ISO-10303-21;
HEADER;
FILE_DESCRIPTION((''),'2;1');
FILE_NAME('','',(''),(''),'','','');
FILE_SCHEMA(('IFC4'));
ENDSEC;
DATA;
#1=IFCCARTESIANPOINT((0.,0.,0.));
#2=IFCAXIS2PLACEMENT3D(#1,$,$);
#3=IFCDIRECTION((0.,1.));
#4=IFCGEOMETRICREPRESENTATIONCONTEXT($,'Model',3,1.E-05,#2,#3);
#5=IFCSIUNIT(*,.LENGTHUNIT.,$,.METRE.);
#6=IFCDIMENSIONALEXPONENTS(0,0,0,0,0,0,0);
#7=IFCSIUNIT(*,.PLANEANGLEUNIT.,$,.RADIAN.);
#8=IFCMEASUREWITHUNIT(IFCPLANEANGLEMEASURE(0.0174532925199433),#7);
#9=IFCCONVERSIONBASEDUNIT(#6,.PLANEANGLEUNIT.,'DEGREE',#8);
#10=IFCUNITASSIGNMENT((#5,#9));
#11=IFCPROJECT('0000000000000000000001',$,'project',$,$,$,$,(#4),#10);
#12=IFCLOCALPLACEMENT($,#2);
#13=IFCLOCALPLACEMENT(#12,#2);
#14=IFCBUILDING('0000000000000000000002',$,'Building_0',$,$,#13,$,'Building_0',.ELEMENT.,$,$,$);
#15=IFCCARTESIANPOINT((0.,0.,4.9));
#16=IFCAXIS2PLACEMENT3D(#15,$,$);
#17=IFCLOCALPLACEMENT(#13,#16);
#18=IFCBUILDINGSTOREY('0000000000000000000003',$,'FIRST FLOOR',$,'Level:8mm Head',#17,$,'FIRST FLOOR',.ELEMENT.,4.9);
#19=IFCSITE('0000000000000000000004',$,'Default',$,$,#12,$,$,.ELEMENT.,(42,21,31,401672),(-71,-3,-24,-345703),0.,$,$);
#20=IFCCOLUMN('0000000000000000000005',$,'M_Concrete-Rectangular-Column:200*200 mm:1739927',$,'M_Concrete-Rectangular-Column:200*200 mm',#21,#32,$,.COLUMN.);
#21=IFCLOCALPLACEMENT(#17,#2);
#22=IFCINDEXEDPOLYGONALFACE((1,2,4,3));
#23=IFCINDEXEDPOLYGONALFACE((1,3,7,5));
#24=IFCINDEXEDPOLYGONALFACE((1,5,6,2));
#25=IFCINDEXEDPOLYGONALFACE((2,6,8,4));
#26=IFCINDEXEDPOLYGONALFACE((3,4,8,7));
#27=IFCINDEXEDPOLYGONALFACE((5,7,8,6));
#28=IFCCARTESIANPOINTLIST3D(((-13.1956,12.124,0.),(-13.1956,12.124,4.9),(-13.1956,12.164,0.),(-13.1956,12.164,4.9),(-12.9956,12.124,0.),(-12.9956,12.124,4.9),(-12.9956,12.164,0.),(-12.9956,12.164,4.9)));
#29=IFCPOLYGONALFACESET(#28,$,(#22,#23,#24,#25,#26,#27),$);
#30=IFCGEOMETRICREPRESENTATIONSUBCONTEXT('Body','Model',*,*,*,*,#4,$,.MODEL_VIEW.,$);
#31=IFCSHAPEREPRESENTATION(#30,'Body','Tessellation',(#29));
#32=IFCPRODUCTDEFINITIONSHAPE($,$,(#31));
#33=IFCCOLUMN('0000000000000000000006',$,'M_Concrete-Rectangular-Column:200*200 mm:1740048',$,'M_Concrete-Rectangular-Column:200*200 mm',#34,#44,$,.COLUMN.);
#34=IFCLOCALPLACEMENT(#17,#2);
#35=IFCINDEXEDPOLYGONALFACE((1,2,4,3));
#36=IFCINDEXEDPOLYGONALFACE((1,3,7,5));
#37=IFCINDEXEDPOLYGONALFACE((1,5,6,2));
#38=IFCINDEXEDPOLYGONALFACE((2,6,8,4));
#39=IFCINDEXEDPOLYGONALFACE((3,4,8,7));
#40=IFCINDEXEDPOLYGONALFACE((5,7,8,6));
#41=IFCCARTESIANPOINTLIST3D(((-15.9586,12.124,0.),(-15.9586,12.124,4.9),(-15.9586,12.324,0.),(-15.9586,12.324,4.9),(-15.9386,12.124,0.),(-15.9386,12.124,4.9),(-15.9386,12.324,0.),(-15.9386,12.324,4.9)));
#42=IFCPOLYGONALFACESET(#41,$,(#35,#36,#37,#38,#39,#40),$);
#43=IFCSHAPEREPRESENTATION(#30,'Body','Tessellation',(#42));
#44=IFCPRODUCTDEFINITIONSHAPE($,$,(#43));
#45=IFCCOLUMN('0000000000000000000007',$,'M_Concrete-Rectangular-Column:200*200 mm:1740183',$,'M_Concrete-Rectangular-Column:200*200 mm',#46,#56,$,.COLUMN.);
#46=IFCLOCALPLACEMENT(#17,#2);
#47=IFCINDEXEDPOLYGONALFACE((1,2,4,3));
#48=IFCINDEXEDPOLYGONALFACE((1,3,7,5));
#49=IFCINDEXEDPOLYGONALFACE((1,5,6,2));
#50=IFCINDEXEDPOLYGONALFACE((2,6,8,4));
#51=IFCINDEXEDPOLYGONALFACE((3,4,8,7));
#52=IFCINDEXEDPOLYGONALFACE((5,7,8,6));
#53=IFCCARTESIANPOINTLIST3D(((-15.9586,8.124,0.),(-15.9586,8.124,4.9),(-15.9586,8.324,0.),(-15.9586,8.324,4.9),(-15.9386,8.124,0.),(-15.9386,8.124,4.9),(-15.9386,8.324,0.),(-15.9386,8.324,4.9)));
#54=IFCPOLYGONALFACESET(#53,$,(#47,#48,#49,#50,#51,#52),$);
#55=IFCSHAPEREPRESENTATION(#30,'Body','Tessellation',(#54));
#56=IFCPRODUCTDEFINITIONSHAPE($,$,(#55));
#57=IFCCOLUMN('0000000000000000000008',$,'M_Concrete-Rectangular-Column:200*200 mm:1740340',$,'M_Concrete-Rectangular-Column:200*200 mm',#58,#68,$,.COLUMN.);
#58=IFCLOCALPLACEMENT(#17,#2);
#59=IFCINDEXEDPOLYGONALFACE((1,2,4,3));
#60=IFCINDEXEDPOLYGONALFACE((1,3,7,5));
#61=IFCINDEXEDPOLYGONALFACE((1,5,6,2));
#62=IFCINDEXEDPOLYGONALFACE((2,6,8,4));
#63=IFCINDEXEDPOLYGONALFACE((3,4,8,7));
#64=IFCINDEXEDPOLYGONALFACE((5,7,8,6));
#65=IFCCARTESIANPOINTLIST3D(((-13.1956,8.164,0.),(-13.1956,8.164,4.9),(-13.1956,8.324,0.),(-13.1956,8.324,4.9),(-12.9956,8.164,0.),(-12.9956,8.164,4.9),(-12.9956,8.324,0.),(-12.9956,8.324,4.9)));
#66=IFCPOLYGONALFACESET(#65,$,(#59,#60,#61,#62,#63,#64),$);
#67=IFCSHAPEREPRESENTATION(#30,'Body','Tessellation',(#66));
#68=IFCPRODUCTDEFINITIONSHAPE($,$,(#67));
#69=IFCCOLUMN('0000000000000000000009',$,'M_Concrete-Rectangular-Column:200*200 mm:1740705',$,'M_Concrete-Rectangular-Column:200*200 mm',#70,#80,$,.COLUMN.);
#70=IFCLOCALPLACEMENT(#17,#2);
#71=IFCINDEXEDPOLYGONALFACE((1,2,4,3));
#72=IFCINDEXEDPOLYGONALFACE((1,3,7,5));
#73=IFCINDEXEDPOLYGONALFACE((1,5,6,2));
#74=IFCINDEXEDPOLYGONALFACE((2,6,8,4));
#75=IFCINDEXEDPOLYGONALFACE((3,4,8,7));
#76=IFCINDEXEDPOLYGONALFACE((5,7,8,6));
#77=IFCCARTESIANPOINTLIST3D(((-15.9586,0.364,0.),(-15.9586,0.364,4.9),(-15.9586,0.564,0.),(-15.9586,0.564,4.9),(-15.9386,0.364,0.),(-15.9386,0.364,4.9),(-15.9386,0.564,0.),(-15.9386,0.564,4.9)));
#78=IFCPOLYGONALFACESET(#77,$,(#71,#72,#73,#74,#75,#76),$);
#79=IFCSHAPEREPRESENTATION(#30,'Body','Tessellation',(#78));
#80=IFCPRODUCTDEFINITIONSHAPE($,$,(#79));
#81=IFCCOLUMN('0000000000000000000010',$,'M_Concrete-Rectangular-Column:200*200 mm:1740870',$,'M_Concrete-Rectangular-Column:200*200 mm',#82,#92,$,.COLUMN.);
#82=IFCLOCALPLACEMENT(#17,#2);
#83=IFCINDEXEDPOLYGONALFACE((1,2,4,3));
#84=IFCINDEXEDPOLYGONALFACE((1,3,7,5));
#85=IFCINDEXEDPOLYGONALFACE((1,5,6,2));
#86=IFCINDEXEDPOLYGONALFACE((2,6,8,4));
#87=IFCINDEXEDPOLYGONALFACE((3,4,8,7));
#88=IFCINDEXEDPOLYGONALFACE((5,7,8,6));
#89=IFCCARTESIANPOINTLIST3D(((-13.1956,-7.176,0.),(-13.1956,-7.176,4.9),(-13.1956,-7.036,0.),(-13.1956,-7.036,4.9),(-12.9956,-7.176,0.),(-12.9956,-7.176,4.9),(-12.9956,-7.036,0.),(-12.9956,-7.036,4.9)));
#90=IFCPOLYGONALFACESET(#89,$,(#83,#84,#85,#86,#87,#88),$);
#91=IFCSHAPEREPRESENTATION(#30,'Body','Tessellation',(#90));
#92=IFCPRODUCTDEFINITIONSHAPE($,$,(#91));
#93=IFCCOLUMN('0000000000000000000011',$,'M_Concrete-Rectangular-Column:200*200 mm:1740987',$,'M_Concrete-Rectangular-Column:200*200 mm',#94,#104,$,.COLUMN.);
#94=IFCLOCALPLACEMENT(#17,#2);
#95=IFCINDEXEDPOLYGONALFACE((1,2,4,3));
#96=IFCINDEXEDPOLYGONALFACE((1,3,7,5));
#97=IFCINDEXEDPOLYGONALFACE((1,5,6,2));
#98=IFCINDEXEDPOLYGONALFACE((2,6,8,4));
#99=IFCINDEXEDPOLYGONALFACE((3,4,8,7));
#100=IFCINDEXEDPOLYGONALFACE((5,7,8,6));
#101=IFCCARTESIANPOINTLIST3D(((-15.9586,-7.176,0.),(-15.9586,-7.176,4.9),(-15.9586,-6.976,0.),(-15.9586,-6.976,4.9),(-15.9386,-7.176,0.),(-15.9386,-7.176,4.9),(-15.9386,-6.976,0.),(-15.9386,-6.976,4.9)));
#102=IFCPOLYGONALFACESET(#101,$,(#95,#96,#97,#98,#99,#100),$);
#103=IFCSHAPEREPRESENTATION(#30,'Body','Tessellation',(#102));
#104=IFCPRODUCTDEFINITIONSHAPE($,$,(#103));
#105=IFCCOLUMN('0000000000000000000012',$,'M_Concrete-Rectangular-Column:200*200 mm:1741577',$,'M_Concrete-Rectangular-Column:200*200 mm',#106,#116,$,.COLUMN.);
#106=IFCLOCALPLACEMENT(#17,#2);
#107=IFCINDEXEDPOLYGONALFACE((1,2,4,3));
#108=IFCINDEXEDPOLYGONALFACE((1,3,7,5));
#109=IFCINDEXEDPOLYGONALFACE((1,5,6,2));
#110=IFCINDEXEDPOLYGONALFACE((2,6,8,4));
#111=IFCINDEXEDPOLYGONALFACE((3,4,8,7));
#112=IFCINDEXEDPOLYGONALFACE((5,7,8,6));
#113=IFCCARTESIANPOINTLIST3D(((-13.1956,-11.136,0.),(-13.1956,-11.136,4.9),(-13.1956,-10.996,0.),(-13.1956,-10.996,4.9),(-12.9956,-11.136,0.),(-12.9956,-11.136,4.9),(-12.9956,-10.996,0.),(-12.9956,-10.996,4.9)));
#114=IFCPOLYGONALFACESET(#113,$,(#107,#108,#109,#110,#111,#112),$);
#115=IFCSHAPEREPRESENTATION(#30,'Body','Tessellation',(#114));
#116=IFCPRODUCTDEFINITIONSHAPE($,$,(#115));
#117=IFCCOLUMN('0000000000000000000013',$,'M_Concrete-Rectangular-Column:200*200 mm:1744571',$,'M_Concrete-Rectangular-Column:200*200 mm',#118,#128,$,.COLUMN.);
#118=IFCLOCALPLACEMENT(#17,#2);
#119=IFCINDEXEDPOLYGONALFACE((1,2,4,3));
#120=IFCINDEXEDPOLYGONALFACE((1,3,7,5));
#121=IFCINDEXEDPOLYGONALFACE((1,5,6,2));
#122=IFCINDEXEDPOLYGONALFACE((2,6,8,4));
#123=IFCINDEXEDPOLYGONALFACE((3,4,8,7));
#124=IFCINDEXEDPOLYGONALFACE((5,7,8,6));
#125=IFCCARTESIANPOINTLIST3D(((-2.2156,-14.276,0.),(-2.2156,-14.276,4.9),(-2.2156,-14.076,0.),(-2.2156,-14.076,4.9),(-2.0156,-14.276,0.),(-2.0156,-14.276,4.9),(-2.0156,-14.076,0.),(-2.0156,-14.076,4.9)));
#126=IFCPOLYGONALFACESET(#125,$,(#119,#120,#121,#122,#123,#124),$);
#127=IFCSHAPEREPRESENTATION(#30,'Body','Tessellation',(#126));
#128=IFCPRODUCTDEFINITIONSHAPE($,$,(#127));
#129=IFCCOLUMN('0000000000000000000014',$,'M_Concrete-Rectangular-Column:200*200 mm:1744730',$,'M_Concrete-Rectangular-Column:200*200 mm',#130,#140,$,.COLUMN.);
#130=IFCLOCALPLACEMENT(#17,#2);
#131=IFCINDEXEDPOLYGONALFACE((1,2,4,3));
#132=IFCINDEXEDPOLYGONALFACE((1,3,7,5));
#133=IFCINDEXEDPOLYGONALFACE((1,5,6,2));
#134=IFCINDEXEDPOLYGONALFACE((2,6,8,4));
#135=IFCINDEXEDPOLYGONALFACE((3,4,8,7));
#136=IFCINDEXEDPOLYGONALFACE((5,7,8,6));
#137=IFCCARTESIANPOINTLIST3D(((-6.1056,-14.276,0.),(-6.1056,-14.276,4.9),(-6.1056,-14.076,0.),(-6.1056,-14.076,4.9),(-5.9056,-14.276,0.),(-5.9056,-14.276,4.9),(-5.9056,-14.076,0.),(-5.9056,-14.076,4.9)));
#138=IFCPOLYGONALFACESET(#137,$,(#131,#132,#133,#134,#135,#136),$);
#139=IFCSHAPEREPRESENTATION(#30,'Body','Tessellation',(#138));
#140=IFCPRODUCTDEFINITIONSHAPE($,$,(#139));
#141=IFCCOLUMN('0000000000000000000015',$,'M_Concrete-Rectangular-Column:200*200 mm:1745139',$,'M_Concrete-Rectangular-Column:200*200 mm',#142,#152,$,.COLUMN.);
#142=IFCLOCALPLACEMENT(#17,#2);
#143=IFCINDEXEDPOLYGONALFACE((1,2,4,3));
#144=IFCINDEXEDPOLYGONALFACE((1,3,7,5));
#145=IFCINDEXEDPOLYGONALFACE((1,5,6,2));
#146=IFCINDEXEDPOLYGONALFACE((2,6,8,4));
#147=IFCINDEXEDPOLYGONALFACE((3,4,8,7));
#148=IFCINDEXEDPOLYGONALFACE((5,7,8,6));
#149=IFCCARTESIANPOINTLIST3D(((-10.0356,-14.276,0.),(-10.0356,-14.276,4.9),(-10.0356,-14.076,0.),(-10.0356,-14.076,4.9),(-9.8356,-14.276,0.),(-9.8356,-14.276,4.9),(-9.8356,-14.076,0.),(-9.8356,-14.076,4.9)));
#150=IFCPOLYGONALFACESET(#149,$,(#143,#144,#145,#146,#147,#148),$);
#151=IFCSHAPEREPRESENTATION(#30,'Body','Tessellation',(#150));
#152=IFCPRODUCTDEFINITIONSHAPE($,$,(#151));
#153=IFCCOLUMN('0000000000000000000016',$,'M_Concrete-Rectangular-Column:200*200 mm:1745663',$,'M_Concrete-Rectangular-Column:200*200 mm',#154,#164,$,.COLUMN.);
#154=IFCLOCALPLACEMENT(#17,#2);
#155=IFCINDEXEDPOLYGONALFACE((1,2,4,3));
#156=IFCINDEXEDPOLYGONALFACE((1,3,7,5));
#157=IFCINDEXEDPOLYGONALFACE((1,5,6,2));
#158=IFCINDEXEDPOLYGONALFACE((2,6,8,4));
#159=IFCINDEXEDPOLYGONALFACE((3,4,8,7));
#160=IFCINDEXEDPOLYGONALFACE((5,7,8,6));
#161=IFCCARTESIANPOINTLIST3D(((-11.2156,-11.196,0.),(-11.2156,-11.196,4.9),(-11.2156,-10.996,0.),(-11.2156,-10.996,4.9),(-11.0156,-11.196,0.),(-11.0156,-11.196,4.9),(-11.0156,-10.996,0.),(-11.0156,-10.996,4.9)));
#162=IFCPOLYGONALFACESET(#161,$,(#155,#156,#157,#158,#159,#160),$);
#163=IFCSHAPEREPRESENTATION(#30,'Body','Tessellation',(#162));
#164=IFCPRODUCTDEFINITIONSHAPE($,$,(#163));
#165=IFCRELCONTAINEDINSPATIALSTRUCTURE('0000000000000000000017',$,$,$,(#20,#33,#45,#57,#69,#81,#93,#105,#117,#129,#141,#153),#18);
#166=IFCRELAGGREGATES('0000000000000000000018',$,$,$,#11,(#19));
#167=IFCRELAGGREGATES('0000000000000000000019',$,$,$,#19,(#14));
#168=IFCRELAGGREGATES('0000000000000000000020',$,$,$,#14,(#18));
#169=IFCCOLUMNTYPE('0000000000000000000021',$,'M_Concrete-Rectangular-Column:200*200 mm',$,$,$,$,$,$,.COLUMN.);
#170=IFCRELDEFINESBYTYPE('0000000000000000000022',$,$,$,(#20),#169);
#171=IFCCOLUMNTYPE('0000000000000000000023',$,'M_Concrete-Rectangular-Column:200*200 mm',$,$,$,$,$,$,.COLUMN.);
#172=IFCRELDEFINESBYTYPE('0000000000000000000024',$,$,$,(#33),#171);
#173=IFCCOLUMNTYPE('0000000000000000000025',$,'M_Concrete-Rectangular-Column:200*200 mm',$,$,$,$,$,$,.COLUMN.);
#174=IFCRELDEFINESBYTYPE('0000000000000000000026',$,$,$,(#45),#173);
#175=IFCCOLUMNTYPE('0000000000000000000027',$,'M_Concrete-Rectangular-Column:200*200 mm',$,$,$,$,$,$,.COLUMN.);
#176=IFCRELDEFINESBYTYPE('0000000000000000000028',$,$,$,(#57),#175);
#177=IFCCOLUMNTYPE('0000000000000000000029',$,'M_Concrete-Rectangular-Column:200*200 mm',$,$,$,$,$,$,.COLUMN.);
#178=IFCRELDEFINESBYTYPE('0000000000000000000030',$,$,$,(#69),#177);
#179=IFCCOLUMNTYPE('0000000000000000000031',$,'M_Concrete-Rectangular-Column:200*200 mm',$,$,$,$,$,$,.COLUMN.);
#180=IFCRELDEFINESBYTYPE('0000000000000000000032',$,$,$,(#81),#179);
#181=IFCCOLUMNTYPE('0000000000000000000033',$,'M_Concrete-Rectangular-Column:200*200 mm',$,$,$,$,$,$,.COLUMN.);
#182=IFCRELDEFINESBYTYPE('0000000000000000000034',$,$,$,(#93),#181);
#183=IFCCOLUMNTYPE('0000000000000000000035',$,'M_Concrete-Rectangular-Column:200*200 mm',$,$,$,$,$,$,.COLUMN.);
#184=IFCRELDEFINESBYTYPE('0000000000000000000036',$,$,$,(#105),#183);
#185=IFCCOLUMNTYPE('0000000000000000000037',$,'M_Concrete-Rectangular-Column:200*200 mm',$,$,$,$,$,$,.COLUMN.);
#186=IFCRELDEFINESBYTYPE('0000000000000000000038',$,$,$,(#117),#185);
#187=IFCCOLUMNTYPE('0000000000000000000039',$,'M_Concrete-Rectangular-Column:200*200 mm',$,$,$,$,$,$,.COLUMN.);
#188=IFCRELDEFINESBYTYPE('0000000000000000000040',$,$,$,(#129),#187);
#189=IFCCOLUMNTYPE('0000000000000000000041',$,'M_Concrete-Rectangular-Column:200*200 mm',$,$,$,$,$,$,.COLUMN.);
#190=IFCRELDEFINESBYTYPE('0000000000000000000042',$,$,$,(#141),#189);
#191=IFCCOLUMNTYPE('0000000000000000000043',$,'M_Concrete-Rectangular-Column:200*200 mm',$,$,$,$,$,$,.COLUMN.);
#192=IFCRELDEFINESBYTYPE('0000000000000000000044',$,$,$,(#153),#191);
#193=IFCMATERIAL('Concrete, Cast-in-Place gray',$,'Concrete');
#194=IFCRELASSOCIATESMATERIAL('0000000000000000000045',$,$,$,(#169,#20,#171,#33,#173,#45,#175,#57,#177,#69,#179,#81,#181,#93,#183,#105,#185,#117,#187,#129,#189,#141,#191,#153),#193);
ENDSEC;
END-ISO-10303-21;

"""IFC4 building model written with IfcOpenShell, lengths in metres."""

from ifc_helpers import new_model, entity, si_unit, converted_unit, direction, frame, origin, place, context, subcontext, project, spatial, indexed_curve, outline, extrude, source, transform, mapped, material, type_object, type_shapes, element, save


model = new_model("IFC4")

# Units and contexts
model_context = context("Model", 3, precision=1e-05, world=origin(), true_north=direction((0.0, 1.0)))
body_context = subcontext(model_context, "Body", "Model", "MODEL_VIEW")
ifc_project = project(units=[si_unit("LENGTHUNIT", "METRE"), converted_unit("PLANEANGLEUNIT", "DEGREE", entity("IfcPlaneAngleMeasure", 0.0174532925199433), si_unit("PLANEANGLEUNIT", "RADIAN"), dimensions=[0, 0, 0, 0, 0, 0, 0])], contexts=[model_context])

# Site, building, storey
site_placement = place(None, origin())
site = spatial("IfcSite", under=ifc_project, at=site_placement, Name="Default", CompositionType="ELEMENT", RefLatitude=(42, 21, 31, 401672), RefLongitude=(-71, -3, -24, -345703), RefElevation=0.0)
building_placement = place(site_placement, origin())
building = spatial("IfcBuilding", under=site, at=building_placement, Name="Building_0", LongName="Building_0", CompositionType="ELEMENT")
storey_placement = place(building_placement, frame((0.0, 0.0, 4.9)))
storey = spatial("IfcBuildingStorey", under=building, at=storey_placement, Name="FIRST FLOOR", ObjectType="Level:8mm Head", LongName="FIRST FLOOR", CompositionType="ELEMENT", Elevation=4.9)

# Columns
ifc_material_1 = material(Name="Concrete, Cast-in-Place gray", Category="Concrete")
column_type_1 = type_object("IfcColumnType", Name="M_Concrete-Rectangular-Column:200*200 mm", PredefinedType="COLUMN", material=ifc_material_1)
shared_shape_1 = source(origin(), body_context, "Body", "SweptSolid", [
    extrude(outline(indexed_curve([(-0.02, -0.1), (0.02, -0.1), (0.02, 0.1), (-0.02, 0.1), (-0.02, -0.1)], self_intersect=False)), frame((-13.0956, 12.144, 4.9), z_axis=(0.0, 0.0, 1.0), x_axis=(0.0, 1.0, 0.0)), (0.0, 0.0, 1.0), 4.9),
])
type_shapes(column_type_1, [shared_shape_1])
column_1_placement = place(storey_placement, frame((0.0, 0.0, -4.9)))
element("IfcColumn", 1, at=column_1_placement, inside=storey, type_object=column_type_1, material=ifc_material_1, Name="M_Concrete-Rectangular-Column:200*200 mm:1739927", ObjectType="M_Concrete-Rectangular-Column:200*200 mm", PredefinedType="COLUMN", context=body_context, shape_type="MappedRepresentation", body=[
    mapped(shared_shape_1, transform((0.0, 0.0, 0.0), scale=1.0)),
])
column_type_2 = type_object("IfcColumnType", Name="M_Concrete-Rectangular-Column:200*200 mm", PredefinedType="COLUMN", material=ifc_material_1)
shared_shape_2 = source(origin(), body_context, "Body", "SweptSolid", [
    extrude(outline(indexed_curve([(-0.01, -0.1), (0.01, -0.1), (0.01, 0.1), (-0.01, 0.1), (-0.01, -0.1)], self_intersect=False)), frame((-15.9486, 12.224, 4.9), z_axis=(0.0, 0.0, 1.0), x_axis=(-1.0, 0.0, 0.0)), (0.0, 0.0, 1.0), 4.9),
])
type_shapes(column_type_2, [shared_shape_2])
column_2_placement = place(storey_placement, frame((0.0, 0.0, -4.9)))
element("IfcColumn", 2, at=column_2_placement, inside=storey, type_object=column_type_2, material=ifc_material_1, Name="M_Concrete-Rectangular-Column:200*200 mm:1740048", ObjectType="M_Concrete-Rectangular-Column:200*200 mm", PredefinedType="COLUMN", context=body_context, shape_type="MappedRepresentation", body=[
    mapped(shared_shape_2, transform((0.0, 0.0, 0.0), scale=1.0)),
])
column_type_3 = type_object("IfcColumnType", Name="M_Concrete-Rectangular-Column:200*200 mm", PredefinedType="COLUMN", material=ifc_material_1)
shared_shape_3 = source(origin(), body_context, "Body", "SweptSolid", [
    extrude(outline(indexed_curve([(-0.01, -0.1), (0.01, -0.1), (0.01, 0.1), (-0.01, 0.1), (-0.01, -0.1)], self_intersect=False)), frame((-15.9486, 8.224, 4.9), z_axis=(0.0, 0.0, 1.0), x_axis=(-1.0, 0.0, 0.0)), (0.0, 0.0, 1.0), 4.9),
])
type_shapes(column_type_3, [shared_shape_3])
column_3_placement = place(storey_placement, frame((0.0, 0.0, -4.9)))
element("IfcColumn", 3, at=column_3_placement, inside=storey, type_object=column_type_3, material=ifc_material_1, Name="M_Concrete-Rectangular-Column:200*200 mm:1740183", ObjectType="M_Concrete-Rectangular-Column:200*200 mm", PredefinedType="COLUMN", context=body_context, shape_type="MappedRepresentation", body=[
    mapped(shared_shape_3, transform((0.0, 0.0, 0.0), scale=1.0)),
])
column_type_4 = type_object("IfcColumnType", Name="M_Concrete-Rectangular-Column:200*200 mm", PredefinedType="COLUMN", material=ifc_material_1)
shared_shape_4 = source(origin(), body_context, "Body", "SweptSolid", [
    extrude(outline(indexed_curve([(-0.08, -0.1), (0.08, -0.1), (0.08, 0.1), (-0.08, 0.1), (-0.08, -0.1)], self_intersect=False)), frame((-13.0956, 8.244, 4.9), z_axis=(0.0, 0.0, 1.0), x_axis=(0.0, -1.0, 0.0)), (0.0, 0.0, 1.0), 4.9),
])
type_shapes(column_type_4, [shared_shape_4])
column_4_placement = place(storey_placement, frame((0.0, 0.0, -4.9)))
element("IfcColumn", 4, at=column_4_placement, inside=storey, type_object=column_type_4, material=ifc_material_1, Name="M_Concrete-Rectangular-Column:200*200 mm:1740340", ObjectType="M_Concrete-Rectangular-Column:200*200 mm", PredefinedType="COLUMN", context=body_context, shape_type="MappedRepresentation", body=[
    mapped(shared_shape_4, transform((0.0, 0.0, 0.0), scale=1.0)),
])
column_type_5 = type_object("IfcColumnType", Name="M_Concrete-Rectangular-Column:200*200 mm", PredefinedType="COLUMN", material=ifc_material_1)
shared_shape_5 = source(origin(), body_context, "Body", "SweptSolid", [
    extrude(outline(indexed_curve([(-0.01, -0.1), (0.01, -0.1), (0.01, 0.1), (-0.01, 0.1), (-0.01, -0.1)], self_intersect=False)), frame((-15.9486, 0.464, 4.9), z_axis=(0.0, 0.0, 1.0), x_axis=(-1.0, 0.0, 0.0)), (0.0, 0.0, 1.0), 4.9),
])
type_shapes(column_type_5, [shared_shape_5])
column_5_placement = place(storey_placement, frame((0.0, 0.0, -4.9)))
element("IfcColumn", 5, at=column_5_placement, inside=storey, type_object=column_type_5, material=ifc_material_1, Name="M_Concrete-Rectangular-Column:200*200 mm:1740705", ObjectType="M_Concrete-Rectangular-Column:200*200 mm", PredefinedType="COLUMN", context=body_context, shape_type="MappedRepresentation", body=[
    mapped(shared_shape_5, transform((0.0, 0.0, 0.0), scale=1.0)),
])
column_type_6 = type_object("IfcColumnType", Name="M_Concrete-Rectangular-Column:200*200 mm", PredefinedType="COLUMN", material=ifc_material_1)
shared_shape_6 = source(origin(), body_context, "Body", "SweptSolid", [
    extrude(outline(indexed_curve([(-0.07, -0.1), (0.07, -0.1), (0.07, 0.1), (-0.07, 0.1), (-0.07, -0.1)], self_intersect=False)), frame((-13.0956, -7.106, 4.9), z_axis=(0.0, 0.0, 1.0), x_axis=(0.0, 1.0, 0.0)), (0.0, 0.0, 1.0), 4.9),
])
type_shapes(column_type_6, [shared_shape_6])
column_6_placement = place(storey_placement, frame((0.0, 0.0, -4.9)))
element("IfcColumn", 6, at=column_6_placement, inside=storey, type_object=column_type_6, material=ifc_material_1, Name="M_Concrete-Rectangular-Column:200*200 mm:1740870", ObjectType="M_Concrete-Rectangular-Column:200*200 mm", PredefinedType="COLUMN", context=body_context, shape_type="MappedRepresentation", body=[
    mapped(shared_shape_6, transform((0.0, 0.0, 0.0), scale=1.0)),
])
column_type_7 = type_object("IfcColumnType", Name="M_Concrete-Rectangular-Column:200*200 mm", PredefinedType="COLUMN", material=ifc_material_1)
shared_shape_7 = source(origin(), body_context, "Body", "SweptSolid", [
    extrude(outline(indexed_curve([(-0.01, -0.1), (0.01, -0.1), (0.01, 0.1), (-0.01, 0.1), (-0.01, -0.1)], self_intersect=False)), frame((-15.9486, -7.076, 4.9), z_axis=(0.0, 0.0, 1.0), x_axis=(-1.0, 0.0, 0.0)), (0.0, 0.0, 1.0), 4.9),
])
type_shapes(column_type_7, [shared_shape_7])
column_7_placement = place(storey_placement, frame((0.0, 0.0, -4.9)))
element("IfcColumn", 7, at=column_7_placement, inside=storey, type_object=column_type_7, material=ifc_material_1, Name="M_Concrete-Rectangular-Column:200*200 mm:1740987", ObjectType="M_Concrete-Rectangular-Column:200*200 mm", PredefinedType="COLUMN", context=body_context, shape_type="MappedRepresentation", body=[
    mapped(shared_shape_7, transform((0.0, 0.0, 0.0), scale=1.0)),
])
column_type_8 = type_object("IfcColumnType", Name="M_Concrete-Rectangular-Column:200*200 mm", PredefinedType="COLUMN", material=ifc_material_1)
shared_shape_8 = source(origin(), body_context, "Body", "SweptSolid", [
    extrude(outline(indexed_curve([(-0.07, -0.1), (0.07, -0.1), (0.07, 0.1), (-0.07, 0.1), (-0.07, -0.1)], self_intersect=False)), frame((-13.0956, -11.066, 4.9), z_axis=(0.0, 0.0, 1.0), x_axis=(0.0, -1.0, 0.0)), (0.0, 0.0, 1.0), 4.9),
])
type_shapes(column_type_8, [shared_shape_8])
column_8_placement = place(storey_placement, frame((0.0, 0.0, -4.9)))
element("IfcColumn", 8, at=column_8_placement, inside=storey, type_object=column_type_8, material=ifc_material_1, Name="M_Concrete-Rectangular-Column:200*200 mm:1741577", ObjectType="M_Concrete-Rectangular-Column:200*200 mm", PredefinedType="COLUMN", context=body_context, shape_type="MappedRepresentation", body=[
    mapped(shared_shape_8, transform((0.0, 0.0, 0.0), scale=1.0)),
])
column_type_9 = type_object("IfcColumnType", Name="M_Concrete-Rectangular-Column:200*200 mm", PredefinedType="COLUMN", material=ifc_material_1)
shared_shape_9 = source(origin(), body_context, "Body", "SweptSolid", [
    extrude(outline(indexed_curve([(-0.1, -0.1), (0.1, -0.1), (0.1, 0.1), (-0.1, 0.1), (-0.1, -0.1)], self_intersect=False)), frame((-2.1156, -14.176, 4.9), z_axis=(0.0, 0.0, 1.0), x_axis=(-1.0, 0.0, 0.0)), (0.0, 0.0, 1.0), 4.9),
])
type_shapes(column_type_9, [shared_shape_9])
column_9_placement = place(storey_placement, frame((0.0, 0.0, -4.9)))
element("IfcColumn", 9, at=column_9_placement, inside=storey, type_object=column_type_9, material=ifc_material_1, Name="M_Concrete-Rectangular-Column:200*200 mm:1744571", ObjectType="M_Concrete-Rectangular-Column:200*200 mm", PredefinedType="COLUMN", context=body_context, shape_type="MappedRepresentation", body=[
    mapped(shared_shape_9, transform((0.0, 0.0, 0.0), scale=1.0)),
])
column_type_10 = type_object("IfcColumnType", Name="M_Concrete-Rectangular-Column:200*200 mm", PredefinedType="COLUMN", material=ifc_material_1)
shared_shape_10 = source(origin(), body_context, "Body", "SweptSolid", [
    extrude(outline(indexed_curve([(-0.1, -0.1), (0.1, -0.1), (0.1, 0.1), (-0.1, 0.1), (-0.1, -0.1)], self_intersect=False)), frame((-6.0056, -14.176, 4.9), z_axis=(0.0, 0.0, 1.0), x_axis=(-1.0, 0.0, 0.0)), (0.0, 0.0, 1.0), 4.9),
])
type_shapes(column_type_10, [shared_shape_10])
column_10_placement = place(storey_placement, frame((0.0, 0.0, -4.9)))
element("IfcColumn", 10, at=column_10_placement, inside=storey, type_object=column_type_10, material=ifc_material_1, Name="M_Concrete-Rectangular-Column:200*200 mm:1744730", ObjectType="M_Concrete-Rectangular-Column:200*200 mm", PredefinedType="COLUMN", context=body_context, shape_type="MappedRepresentation", body=[
    mapped(shared_shape_10, transform((0.0, 0.0, 0.0), scale=1.0)),
])
column_type_11 = type_object("IfcColumnType", Name="M_Concrete-Rectangular-Column:200*200 mm", PredefinedType="COLUMN", material=ifc_material_1)
shared_shape_11 = source(origin(), body_context, "Body", "SweptSolid", [
    extrude(outline(indexed_curve([(-0.1, -0.1), (0.1, -0.1), (0.1, 0.1), (-0.1, 0.1), (-0.1, -0.1)], self_intersect=False)), frame((-9.9356, -14.176, 4.9), z_axis=(0.0, 0.0, 1.0), x_axis=(-1.0, 0.0, 0.0)), (0.0, 0.0, 1.0), 4.9),
])
type_shapes(column_type_11, [shared_shape_11])
column_11_placement = place(storey_placement, frame((0.0, 0.0, -4.9)))
element("IfcColumn", 11, at=column_11_placement, inside=storey, type_object=column_type_11, material=ifc_material_1, Name="M_Concrete-Rectangular-Column:200*200 mm:1745139", ObjectType="M_Concrete-Rectangular-Column:200*200 mm", PredefinedType="COLUMN", context=body_context, shape_type="MappedRepresentation", body=[
    mapped(shared_shape_11, transform((0.0, 0.0, 0.0), scale=1.0)),
])
column_type_12 = type_object("IfcColumnType", Name="M_Concrete-Rectangular-Column:200*200 mm", PredefinedType="COLUMN", material=ifc_material_1)
shared_shape_12 = source(origin(), body_context, "Body", "SweptSolid", [
    extrude(outline(indexed_curve([(-0.1, -0.1), (0.1, -0.1), (0.1, 0.1), (-0.1, 0.1), (-0.1, -0.1)], self_intersect=False)), frame((-11.1156, -11.096, 4.9), z_axis=(0.0, 0.0, 1.0), x_axis=(-1.0, 0.0, 0.0)), (0.0, 0.0, 1.0), 4.9),
])
type_shapes(column_type_12, [shared_shape_12])
column_12_placement = place(storey_placement, frame((0.0, 0.0, -4.9)))
element("IfcColumn", 12, at=column_12_placement, inside=storey, type_object=column_type_12, material=ifc_material_1, Name="M_Concrete-Rectangular-Column:200*200 mm:1745663", ObjectType="M_Concrete-Rectangular-Column:200*200 mm", PredefinedType="COLUMN", context=body_context, shape_type="MappedRepresentation", body=[
    mapped(shared_shape_12, transform((0.0, 0.0, 0.0), scale=1.0)),
])

save(model, "model.ifc")
